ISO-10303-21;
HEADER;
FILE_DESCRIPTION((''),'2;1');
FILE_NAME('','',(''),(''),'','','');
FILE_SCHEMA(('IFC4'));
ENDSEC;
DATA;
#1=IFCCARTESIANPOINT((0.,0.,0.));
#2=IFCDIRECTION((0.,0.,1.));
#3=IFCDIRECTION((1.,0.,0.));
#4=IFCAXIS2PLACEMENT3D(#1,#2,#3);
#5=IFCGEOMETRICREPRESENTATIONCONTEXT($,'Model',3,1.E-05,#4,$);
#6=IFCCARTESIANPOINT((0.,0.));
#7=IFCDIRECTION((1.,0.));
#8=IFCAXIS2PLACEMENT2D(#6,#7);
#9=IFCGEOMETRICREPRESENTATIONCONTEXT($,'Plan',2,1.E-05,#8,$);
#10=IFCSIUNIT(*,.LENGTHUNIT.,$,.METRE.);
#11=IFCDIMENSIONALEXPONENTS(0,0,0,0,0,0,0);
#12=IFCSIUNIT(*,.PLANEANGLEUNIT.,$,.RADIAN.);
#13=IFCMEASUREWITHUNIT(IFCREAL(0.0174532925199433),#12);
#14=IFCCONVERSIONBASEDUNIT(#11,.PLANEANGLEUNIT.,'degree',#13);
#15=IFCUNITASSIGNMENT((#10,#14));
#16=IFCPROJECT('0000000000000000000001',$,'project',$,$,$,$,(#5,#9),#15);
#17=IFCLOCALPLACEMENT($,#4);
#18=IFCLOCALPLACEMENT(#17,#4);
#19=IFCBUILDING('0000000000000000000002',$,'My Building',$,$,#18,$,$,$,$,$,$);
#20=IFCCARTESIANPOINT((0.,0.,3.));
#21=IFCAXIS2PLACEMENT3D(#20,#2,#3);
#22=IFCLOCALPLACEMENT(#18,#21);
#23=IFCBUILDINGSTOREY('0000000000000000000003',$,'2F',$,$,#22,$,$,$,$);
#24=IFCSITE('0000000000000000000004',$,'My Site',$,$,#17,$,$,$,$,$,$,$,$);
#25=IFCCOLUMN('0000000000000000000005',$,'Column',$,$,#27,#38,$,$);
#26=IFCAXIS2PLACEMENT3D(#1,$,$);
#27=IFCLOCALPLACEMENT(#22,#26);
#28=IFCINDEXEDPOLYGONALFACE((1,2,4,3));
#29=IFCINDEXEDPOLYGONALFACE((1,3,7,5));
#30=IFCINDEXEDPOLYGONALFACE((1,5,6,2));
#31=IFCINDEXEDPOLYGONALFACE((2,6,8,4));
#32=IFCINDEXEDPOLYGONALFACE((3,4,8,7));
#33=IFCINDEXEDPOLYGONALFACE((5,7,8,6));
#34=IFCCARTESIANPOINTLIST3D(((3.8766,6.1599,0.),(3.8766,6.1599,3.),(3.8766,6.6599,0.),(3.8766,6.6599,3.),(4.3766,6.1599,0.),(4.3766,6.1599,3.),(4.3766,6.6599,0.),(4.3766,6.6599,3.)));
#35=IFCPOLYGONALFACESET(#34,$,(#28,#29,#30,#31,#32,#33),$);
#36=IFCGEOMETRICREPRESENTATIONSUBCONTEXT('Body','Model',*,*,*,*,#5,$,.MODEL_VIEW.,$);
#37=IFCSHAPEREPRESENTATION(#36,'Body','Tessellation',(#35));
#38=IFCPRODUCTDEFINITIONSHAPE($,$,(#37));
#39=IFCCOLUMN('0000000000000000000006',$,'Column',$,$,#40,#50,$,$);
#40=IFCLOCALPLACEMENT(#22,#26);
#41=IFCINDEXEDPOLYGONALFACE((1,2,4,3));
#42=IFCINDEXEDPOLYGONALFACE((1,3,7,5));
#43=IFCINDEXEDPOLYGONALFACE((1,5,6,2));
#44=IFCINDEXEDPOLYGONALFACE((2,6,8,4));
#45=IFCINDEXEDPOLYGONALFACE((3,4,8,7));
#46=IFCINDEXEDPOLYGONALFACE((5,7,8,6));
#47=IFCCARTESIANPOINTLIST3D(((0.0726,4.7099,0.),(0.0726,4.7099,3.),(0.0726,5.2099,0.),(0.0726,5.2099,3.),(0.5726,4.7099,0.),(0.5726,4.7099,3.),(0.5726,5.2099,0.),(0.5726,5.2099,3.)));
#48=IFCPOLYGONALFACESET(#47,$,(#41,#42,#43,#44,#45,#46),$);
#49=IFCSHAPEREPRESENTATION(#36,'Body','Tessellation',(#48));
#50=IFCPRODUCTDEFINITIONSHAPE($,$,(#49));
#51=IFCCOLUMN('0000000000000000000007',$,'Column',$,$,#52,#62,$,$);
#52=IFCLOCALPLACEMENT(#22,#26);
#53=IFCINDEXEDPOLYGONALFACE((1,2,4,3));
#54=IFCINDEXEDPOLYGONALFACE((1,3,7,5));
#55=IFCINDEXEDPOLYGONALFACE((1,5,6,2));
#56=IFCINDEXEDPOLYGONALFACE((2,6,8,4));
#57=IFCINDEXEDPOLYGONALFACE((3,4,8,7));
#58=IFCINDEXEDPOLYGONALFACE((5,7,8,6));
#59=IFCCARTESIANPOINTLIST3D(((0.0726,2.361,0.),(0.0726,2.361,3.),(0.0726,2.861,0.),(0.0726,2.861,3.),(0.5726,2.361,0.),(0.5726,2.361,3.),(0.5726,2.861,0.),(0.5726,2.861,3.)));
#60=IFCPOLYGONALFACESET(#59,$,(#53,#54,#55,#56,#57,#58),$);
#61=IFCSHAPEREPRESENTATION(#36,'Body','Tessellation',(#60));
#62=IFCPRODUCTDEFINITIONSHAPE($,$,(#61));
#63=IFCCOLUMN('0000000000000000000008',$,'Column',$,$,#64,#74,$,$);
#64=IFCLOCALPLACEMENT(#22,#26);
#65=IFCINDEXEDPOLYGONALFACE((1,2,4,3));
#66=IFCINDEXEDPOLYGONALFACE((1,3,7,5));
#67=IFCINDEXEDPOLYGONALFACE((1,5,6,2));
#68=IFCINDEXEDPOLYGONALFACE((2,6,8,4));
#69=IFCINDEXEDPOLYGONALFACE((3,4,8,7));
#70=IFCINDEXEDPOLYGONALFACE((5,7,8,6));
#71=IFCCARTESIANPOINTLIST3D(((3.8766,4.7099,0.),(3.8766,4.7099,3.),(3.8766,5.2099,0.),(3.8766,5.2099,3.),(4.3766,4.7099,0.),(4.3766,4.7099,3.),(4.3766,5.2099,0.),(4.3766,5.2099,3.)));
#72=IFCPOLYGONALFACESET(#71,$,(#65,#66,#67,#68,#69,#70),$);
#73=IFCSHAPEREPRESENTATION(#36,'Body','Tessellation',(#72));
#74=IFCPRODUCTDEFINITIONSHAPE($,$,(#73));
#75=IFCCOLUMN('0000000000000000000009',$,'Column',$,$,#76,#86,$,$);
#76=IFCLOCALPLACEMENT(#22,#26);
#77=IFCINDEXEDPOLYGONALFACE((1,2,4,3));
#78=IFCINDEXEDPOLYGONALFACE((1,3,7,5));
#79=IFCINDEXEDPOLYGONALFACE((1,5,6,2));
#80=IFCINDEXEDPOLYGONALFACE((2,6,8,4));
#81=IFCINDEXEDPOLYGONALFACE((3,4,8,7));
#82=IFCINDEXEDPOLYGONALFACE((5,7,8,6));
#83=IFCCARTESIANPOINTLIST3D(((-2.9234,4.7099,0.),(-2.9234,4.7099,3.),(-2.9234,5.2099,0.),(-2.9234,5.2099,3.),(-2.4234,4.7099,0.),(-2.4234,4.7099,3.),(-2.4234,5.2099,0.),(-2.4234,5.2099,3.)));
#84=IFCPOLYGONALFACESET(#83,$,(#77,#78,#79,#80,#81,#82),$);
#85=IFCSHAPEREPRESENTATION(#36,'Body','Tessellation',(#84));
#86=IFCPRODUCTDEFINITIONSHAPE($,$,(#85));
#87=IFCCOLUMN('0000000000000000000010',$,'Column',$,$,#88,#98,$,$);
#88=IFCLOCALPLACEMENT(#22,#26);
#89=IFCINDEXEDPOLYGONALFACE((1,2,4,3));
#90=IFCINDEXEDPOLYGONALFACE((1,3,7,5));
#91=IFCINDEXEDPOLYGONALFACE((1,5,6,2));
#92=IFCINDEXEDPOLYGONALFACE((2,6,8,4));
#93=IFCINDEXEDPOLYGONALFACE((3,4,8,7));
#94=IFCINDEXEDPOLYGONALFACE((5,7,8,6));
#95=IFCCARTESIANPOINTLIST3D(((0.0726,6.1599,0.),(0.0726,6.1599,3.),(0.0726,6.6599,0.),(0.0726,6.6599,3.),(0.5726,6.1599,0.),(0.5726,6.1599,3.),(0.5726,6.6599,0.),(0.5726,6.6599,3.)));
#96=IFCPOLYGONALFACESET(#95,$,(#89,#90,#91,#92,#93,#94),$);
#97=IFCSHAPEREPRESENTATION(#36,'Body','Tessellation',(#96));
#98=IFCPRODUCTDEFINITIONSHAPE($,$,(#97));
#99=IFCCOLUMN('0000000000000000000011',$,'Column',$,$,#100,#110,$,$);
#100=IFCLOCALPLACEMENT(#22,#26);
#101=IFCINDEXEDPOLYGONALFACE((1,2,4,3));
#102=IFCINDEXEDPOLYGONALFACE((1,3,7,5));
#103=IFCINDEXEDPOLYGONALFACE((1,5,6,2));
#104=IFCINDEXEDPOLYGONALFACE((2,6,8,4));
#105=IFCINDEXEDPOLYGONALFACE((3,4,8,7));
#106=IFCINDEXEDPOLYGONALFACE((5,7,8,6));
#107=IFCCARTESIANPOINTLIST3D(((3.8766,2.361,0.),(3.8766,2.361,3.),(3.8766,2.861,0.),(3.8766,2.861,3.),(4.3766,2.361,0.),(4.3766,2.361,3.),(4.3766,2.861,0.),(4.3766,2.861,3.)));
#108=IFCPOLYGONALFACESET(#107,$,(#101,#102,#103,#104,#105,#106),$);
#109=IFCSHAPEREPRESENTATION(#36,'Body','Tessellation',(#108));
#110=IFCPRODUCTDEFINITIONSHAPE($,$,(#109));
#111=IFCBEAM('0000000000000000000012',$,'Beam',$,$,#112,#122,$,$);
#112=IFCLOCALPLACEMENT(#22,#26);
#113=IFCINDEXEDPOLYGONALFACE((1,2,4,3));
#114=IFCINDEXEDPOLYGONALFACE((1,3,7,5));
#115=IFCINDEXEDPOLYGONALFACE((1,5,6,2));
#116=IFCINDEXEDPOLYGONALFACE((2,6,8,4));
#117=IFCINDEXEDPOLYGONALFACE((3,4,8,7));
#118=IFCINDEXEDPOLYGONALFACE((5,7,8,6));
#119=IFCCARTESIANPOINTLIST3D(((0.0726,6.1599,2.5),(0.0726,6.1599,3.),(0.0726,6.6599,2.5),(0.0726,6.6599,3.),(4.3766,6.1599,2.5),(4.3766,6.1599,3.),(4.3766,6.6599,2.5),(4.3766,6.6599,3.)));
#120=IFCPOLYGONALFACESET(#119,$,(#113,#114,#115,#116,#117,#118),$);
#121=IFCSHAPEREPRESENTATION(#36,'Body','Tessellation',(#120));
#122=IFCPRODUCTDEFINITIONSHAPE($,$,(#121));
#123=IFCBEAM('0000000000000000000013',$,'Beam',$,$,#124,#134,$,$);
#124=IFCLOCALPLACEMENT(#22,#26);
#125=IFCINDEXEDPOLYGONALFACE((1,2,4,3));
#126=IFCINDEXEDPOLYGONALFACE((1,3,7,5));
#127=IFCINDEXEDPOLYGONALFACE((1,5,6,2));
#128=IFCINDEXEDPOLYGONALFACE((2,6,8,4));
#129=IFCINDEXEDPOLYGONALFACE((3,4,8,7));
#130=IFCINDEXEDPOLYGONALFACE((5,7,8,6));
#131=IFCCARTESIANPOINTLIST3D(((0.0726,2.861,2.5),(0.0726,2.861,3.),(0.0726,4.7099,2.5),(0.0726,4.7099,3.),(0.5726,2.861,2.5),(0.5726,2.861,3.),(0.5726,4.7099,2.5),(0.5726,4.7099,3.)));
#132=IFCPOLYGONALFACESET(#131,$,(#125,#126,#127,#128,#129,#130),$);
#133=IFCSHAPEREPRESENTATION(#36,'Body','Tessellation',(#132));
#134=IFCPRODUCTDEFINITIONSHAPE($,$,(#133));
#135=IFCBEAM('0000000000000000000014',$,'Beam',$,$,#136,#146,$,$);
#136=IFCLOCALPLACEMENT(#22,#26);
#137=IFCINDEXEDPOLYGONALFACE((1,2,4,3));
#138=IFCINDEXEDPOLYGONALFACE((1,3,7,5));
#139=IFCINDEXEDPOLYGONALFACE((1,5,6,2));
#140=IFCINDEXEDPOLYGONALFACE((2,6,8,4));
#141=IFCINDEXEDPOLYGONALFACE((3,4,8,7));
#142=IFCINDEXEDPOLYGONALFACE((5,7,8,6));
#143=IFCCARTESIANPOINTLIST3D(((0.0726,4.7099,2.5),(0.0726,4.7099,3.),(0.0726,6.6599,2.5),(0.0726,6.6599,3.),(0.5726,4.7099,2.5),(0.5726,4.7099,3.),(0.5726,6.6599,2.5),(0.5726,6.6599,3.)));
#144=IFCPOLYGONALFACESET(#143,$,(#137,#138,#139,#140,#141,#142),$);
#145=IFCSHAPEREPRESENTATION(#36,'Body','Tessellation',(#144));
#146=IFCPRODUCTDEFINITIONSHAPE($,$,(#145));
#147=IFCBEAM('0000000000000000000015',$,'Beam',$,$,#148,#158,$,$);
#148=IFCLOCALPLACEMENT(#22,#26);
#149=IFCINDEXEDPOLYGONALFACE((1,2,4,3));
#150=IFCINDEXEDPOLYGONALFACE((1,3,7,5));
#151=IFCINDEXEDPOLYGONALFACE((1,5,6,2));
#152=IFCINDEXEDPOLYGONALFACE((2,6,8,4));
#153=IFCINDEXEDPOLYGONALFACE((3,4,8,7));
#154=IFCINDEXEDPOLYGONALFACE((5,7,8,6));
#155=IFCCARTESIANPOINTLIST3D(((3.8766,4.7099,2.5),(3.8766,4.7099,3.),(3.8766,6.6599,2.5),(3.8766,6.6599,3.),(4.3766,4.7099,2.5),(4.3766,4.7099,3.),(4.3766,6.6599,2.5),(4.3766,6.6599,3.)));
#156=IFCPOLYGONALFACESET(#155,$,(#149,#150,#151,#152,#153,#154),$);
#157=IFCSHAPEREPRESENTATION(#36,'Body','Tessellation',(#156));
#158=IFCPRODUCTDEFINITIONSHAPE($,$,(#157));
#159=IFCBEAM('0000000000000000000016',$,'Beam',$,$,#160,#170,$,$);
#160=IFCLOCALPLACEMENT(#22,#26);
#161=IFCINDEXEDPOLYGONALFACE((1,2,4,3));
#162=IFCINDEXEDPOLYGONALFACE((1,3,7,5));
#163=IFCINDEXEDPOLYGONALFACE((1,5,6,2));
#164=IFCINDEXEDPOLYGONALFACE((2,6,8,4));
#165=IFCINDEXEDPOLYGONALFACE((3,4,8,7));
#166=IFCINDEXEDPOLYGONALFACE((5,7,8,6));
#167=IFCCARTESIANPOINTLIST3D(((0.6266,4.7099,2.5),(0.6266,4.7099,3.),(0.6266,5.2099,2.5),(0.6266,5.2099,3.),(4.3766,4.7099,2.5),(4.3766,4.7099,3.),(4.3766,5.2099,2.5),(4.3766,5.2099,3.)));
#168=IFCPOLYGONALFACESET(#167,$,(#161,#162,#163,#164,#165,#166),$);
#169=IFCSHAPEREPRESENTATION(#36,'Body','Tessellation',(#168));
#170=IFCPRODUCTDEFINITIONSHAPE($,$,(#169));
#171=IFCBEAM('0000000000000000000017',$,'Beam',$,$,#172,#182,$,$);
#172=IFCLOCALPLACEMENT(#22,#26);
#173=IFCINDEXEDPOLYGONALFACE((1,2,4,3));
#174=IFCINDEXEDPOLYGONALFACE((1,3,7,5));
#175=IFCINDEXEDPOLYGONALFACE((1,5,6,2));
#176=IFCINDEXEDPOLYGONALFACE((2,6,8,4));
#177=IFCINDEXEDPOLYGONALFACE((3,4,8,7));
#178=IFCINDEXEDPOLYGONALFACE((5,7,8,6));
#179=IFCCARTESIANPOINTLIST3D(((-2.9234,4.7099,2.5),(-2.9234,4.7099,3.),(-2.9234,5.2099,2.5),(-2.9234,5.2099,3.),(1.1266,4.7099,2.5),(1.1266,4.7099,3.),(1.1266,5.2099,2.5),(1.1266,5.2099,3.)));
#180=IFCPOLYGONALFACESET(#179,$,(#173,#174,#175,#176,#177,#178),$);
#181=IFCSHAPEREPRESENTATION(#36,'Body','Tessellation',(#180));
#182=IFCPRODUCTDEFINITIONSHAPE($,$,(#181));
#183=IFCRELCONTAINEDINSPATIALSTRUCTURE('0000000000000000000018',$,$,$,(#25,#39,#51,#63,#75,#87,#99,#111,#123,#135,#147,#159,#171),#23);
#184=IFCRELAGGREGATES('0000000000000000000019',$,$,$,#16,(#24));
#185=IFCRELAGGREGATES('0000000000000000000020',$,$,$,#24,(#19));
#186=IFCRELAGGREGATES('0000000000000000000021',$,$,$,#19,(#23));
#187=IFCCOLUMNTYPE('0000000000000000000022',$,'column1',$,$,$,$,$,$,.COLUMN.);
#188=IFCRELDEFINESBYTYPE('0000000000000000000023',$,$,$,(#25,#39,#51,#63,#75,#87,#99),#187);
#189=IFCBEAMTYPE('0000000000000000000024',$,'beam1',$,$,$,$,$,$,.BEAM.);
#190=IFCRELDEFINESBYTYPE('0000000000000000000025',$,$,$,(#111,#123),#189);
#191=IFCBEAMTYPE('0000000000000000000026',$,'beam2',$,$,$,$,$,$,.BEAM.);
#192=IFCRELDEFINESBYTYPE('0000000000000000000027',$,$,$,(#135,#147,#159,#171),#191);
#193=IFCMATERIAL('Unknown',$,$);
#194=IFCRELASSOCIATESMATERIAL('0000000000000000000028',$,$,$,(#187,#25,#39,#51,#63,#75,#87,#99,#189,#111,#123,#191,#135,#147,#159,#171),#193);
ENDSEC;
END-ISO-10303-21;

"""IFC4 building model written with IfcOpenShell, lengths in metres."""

from ifc_helpers import new_model, entity, si_unit, converted_unit, frame, origin_with_axes, origin_2d_with_axis, place, context, subcontext, project, spatial, rectangle, extrude, material, material_profile, profile_set, profile_usage, type_object, element, save


model = new_model("IFC4")

# Units and contexts
model_context = context("Model", 3, precision=1e-05, world=origin_with_axes())
plan_context = context("Plan", 2, precision=1e-05, world=origin_2d_with_axis())
body_context_1 = subcontext(model_context, "Body", "Model", "MODEL_VIEW")
ifc_project = project(units=[si_unit("LENGTHUNIT", "METRE"), converted_unit("PLANEANGLEUNIT", "degree", entity("IfcReal", 0.0174532925199433), si_unit("PLANEANGLEUNIT", "RADIAN"), dimensions=[0, 0, 0, 0, 0, 0, 0])], contexts=[model_context, plan_context])

# Site, building, storey
site_placement = place(None, origin_with_axes())
site = spatial("IfcSite", under=ifc_project, at=site_placement, Name="My Site")
building_placement = place(site_placement, origin_with_axes())
building = spatial("IfcBuilding", under=site, at=building_placement, Name="My Building")
storey_placement = place(building_placement, frame((0.0, 0.0, 3.0), z_axis=(0.0, 0.0, 1.0), x_axis=(1.0, 0.0, 0.0)))
storey = spatial("IfcBuildingStorey", under=building, at=storey_placement, Name="2F")

# Columns
ifc_material = material(Name="Unknown")
ifc_material_profile_1 = material_profile(ifc_material, rectangle(XDim=0.5, YDim=0.5))
ifc_profile_set_1 = profile_set([ifc_material_profile_1])
ifc_profile_usage_1 = profile_usage(ifc_profile_set_1, cardinal=7)
column_type = type_object("IfcColumnType", Name="column1", PredefinedType="COLUMN", material=ifc_profile_set_1)
column_1_placement = place(storey_placement, frame((4.3766, 6.6599, 0.0), z_axis=(0.0, 0.0, 1.0), x_axis=(1.0, 0.0, 0.0)))
element("IfcColumn", 1, at=column_1_placement, inside=storey, type_object=column_type, material=ifc_profile_usage_1, Name="Column", context=body_context_1, shape_type="SweptSolid", body=[
    extrude(rectangle(XDim=0.5, YDim=0.5), frame((-0.25, -0.25, 0.0), z_axis=(0.0, 0.0, 1.0), x_axis=(1.0, 0.0, 0.0)), (0.0, 0.0, 1.0), 3.0),
])
ifc_profile_usage_2 = profile_usage(ifc_profile_set_1, cardinal=7)
column_2_placement = place(storey_placement, frame((0.5726, 5.2099, 0.0), z_axis=(0.0, 0.0, 1.0), x_axis=(1.0, 0.0, 0.0)))
element("IfcColumn", 2, at=column_2_placement, inside=storey, type_object=column_type, material=ifc_profile_usage_2, Name="Column", context=body_context_1, shape_type="SweptSolid", body=[
    extrude(rectangle(XDim=0.5, YDim=0.5), frame((-0.25, -0.25, 0.0), z_axis=(0.0, 0.0, 1.0), x_axis=(1.0, 0.0, 0.0)), (0.0, 0.0, 1.0), 3.0),
])
ifc_profile_usage_3 = profile_usage(ifc_profile_set_1, cardinal=7)
column_3_placement = place(storey_placement, frame((0.5726, 2.861, 0.0), z_axis=(0.0, 0.0, 1.0), x_axis=(1.0, 0.0, 0.0)))
element("IfcColumn", 3, at=column_3_placement, inside=storey, type_object=column_type, material=ifc_profile_usage_3, Name="Column", context=body_context_1, shape_type="SweptSolid", body=[
    extrude(rectangle(XDim=0.5, YDim=0.5), frame((-0.25, -0.25, 0.0), z_axis=(0.0, 0.0, 1.0), x_axis=(1.0, 0.0, 0.0)), (0.0, 0.0, 1.0), 3.0),
])
ifc_profile_usage_4 = profile_usage(ifc_profile_set_1, cardinal=7)
column_4_placement = place(storey_placement, frame((4.3766, 5.2099, 0.0), z_axis=(0.0, 0.0, 1.0), x_axis=(1.0, 0.0, 0.0)))
element("IfcColumn", 4, at=column_4_placement, inside=storey, type_object=column_type, material=ifc_profile_usage_4, Name="Column", context=body_context_1, shape_type="SweptSolid", body=[
    extrude(rectangle(XDim=0.5, YDim=0.5), frame((-0.25, -0.25, 0.0), z_axis=(0.0, 0.0, 1.0), x_axis=(1.0, 0.0, 0.0)), (0.0, 0.0, 1.0), 3.0),
])
ifc_profile_usage_5 = profile_usage(ifc_profile_set_1, cardinal=7)
column_5_placement = place(storey_placement, frame((-2.4234, 5.2099, 0.0), z_axis=(0.0, 0.0, 1.0), x_axis=(1.0, 0.0, 0.0)))
element("IfcColumn", 5, at=column_5_placement, inside=storey, type_object=column_type, material=ifc_profile_usage_5, Name="Column", context=body_context_1, shape_type="SweptSolid", body=[
    extrude(rectangle(XDim=0.5, YDim=0.5), frame((-0.25, -0.25, 0.0), z_axis=(0.0, 0.0, 1.0), x_axis=(1.0, 0.0, 0.0)), (0.0, 0.0, 1.0), 3.0),
])
ifc_profile_usage_6 = profile_usage(ifc_profile_set_1, cardinal=7)
column_6_placement = place(storey_placement, frame((0.5726, 6.6599, 0.0), z_axis=(0.0, 0.0, 1.0), x_axis=(1.0, 0.0, 0.0)))
element("IfcColumn", 6, at=column_6_placement, inside=storey, type_object=column_type, material=ifc_profile_usage_6, Name="Column", context=body_context_1, shape_type="SweptSolid", body=[
    extrude(rectangle(XDim=0.5, YDim=0.5), frame((-0.25, -0.25, 0.0), z_axis=(0.0, 0.0, 1.0), x_axis=(1.0, 0.0, 0.0)), (0.0, 0.0, 1.0), 3.0),
])
ifc_profile_usage_7 = profile_usage(ifc_profile_set_1, cardinal=7)
column_7_placement = place(storey_placement, frame((4.3766, 2.861, 0.0), z_axis=(0.0, 0.0, 1.0), x_axis=(1.0, 0.0, 0.0)))
element("IfcColumn", 7, at=column_7_placement, inside=storey, type_object=column_type, material=ifc_profile_usage_7, Name="Column", context=body_context_1, shape_type="SweptSolid", body=[
    extrude(rectangle(XDim=0.5, YDim=0.5), frame((-0.25, -0.25, 0.0), z_axis=(0.0, 0.0, 1.0), x_axis=(1.0, 0.0, 0.0)), (0.0, 0.0, 1.0), 3.0),
])

# Beams
ifc_material_profile_2 = material_profile(ifc_material, rectangle(XDim=0.5, YDim=0.5))
ifc_profile_set_2 = profile_set([ifc_material_profile_2])
ifc_profile_usage_8 = profile_usage(ifc_profile_set_2, cardinal=7)
beam_type_1 = type_object("IfcBeamType", Name="beam1", PredefinedType="BEAM", material=ifc_profile_set_2)
beam_1_placement = place(storey_placement, frame((0.0726, 6.6599, 3.0), z_axis=(1.0, -0.000001, 0.000001), x_axis=(0.000001, 1.0, 0.0)))
element("IfcBeam", 8, at=beam_1_placement, inside=storey, type_object=beam_type_1, material=ifc_profile_usage_8, Name="Beam", context=body_context_1, shape_type="SweptSolid", body=[
    extrude(rectangle(XDim=0.5, YDim=0.5), frame((-0.25, -0.25, 0.0), z_axis=(0.0, 0.0, 1.0), x_axis=(1.0, 0.0, 0.0)), (0.0, 0.0, 1.0), 4.304),
])
ifc_profile_usage_9 = profile_usage(ifc_profile_set_2, cardinal=7)
beam_2_placement = place(storey_placement, frame((0.5726, 4.7099, 3.0), z_axis=(0.0, -1.0, 0.0), x_axis=(1.0, 0.0, 0.0)))
element("IfcBeam", 9, at=beam_2_placement, inside=storey, type_object=beam_type_1, material=ifc_profile_usage_9, Name="Beam", context=body_context_1, shape_type="SweptSolid", body=[
    extrude(rectangle(XDim=0.5, YDim=0.5), frame((-0.25, -0.25, 0.0), z_axis=(0.0, 0.0, 1.0), x_axis=(1.0, 0.0, 0.0)), (0.0, 0.0, 1.0), 1.8489),
])
ifc_material_profile_3 = material_profile(ifc_material, rectangle(XDim=0.5, YDim=0.5))
ifc_profile_set_3 = profile_set([ifc_material_profile_3])
ifc_profile_usage_10 = profile_usage(ifc_profile_set_3, cardinal=7)
beam_type_2 = type_object("IfcBeamType", Name="beam2", PredefinedType="BEAM", material=ifc_profile_set_3)
beam_3_placement = place(storey_placement, frame((0.5726, 6.6599, 3.0), z_axis=(0.0, -1.0, 0.0), x_axis=(1.0, 0.0, 0.0)))
element("IfcBeam", 10, at=beam_3_placement, inside=storey, type_object=beam_type_2, material=ifc_profile_usage_10, Name="Beam", context=body_context_1, shape_type="SweptSolid", body=[
    extrude(rectangle(XDim=0.5, YDim=0.5), frame((-0.25, -0.25, 0.0), z_axis=(0.0, 0.0, 1.0), x_axis=(1.0, 0.0, 0.0)), (0.0, 0.0, 1.0), 1.95),
])
ifc_profile_usage_11 = profile_usage(ifc_profile_set_3, cardinal=7)
beam_4_placement = place(storey_placement, frame((3.8766, 4.7099, 3.0), z_axis=(0.0, 1.0, 0.0), x_axis=(-1.0, 0.0, 0.0)))
element("IfcBeam", 11, at=beam_4_placement, inside=storey, type_object=beam_type_2, material=ifc_profile_usage_11, Name="Beam", context=body_context_1, shape_type="SweptSolid", body=[
    extrude(rectangle(XDim=0.5, YDim=0.5), frame((-0.25, -0.25, 0.0), z_axis=(0.0, 0.0, 1.0), x_axis=(1.0, 0.0, 0.0)), (0.0, 0.0, 1.0), 1.95),
])
ifc_profile_usage_12 = profile_usage(ifc_profile_set_3, cardinal=7)
beam_5_placement = place(storey_placement, frame((4.3766, 4.7099, 3.0), z_axis=(-1.0, 0.0, 0.0), x_axis=(0.0, -1.0, 0.0)))
element("IfcBeam", 12, at=beam_5_placement, inside=storey, type_object=beam_type_2, material=ifc_profile_usage_12, Name="Beam", context=body_context_1, shape_type="SweptSolid", body=[
    extrude(rectangle(XDim=0.5, YDim=0.5), frame((-0.25, -0.25, 0.0), z_axis=(0.0, 0.0, 1.0), x_axis=(1.0, 0.0, 0.0)), (0.0, 0.0, 1.0), 3.75),
])
ifc_profile_usage_13 = profile_usage(ifc_profile_set_3, cardinal=7)
beam_6_placement = place(storey_placement, frame((1.1266, 4.7099, 3.0), z_axis=(-1.0, 0.0, 0.0), x_axis=(0.0, -1.0, 0.0)))
element("IfcBeam", 13, at=beam_6_placement, inside=storey, type_object=beam_type_2, material=ifc_profile_usage_13, Name="Beam", context=body_context_1, shape_type="SweptSolid", body=[
    extrude(rectangle(XDim=0.5, YDim=0.5), frame((-0.25, -0.25, 0.0), z_axis=(0.0, 0.0, 1.0), x_axis=(1.0, 0.0, 0.0)), (0.0, 0.0, 1.0), 4.05),
])

save(model, "model.ifc")
